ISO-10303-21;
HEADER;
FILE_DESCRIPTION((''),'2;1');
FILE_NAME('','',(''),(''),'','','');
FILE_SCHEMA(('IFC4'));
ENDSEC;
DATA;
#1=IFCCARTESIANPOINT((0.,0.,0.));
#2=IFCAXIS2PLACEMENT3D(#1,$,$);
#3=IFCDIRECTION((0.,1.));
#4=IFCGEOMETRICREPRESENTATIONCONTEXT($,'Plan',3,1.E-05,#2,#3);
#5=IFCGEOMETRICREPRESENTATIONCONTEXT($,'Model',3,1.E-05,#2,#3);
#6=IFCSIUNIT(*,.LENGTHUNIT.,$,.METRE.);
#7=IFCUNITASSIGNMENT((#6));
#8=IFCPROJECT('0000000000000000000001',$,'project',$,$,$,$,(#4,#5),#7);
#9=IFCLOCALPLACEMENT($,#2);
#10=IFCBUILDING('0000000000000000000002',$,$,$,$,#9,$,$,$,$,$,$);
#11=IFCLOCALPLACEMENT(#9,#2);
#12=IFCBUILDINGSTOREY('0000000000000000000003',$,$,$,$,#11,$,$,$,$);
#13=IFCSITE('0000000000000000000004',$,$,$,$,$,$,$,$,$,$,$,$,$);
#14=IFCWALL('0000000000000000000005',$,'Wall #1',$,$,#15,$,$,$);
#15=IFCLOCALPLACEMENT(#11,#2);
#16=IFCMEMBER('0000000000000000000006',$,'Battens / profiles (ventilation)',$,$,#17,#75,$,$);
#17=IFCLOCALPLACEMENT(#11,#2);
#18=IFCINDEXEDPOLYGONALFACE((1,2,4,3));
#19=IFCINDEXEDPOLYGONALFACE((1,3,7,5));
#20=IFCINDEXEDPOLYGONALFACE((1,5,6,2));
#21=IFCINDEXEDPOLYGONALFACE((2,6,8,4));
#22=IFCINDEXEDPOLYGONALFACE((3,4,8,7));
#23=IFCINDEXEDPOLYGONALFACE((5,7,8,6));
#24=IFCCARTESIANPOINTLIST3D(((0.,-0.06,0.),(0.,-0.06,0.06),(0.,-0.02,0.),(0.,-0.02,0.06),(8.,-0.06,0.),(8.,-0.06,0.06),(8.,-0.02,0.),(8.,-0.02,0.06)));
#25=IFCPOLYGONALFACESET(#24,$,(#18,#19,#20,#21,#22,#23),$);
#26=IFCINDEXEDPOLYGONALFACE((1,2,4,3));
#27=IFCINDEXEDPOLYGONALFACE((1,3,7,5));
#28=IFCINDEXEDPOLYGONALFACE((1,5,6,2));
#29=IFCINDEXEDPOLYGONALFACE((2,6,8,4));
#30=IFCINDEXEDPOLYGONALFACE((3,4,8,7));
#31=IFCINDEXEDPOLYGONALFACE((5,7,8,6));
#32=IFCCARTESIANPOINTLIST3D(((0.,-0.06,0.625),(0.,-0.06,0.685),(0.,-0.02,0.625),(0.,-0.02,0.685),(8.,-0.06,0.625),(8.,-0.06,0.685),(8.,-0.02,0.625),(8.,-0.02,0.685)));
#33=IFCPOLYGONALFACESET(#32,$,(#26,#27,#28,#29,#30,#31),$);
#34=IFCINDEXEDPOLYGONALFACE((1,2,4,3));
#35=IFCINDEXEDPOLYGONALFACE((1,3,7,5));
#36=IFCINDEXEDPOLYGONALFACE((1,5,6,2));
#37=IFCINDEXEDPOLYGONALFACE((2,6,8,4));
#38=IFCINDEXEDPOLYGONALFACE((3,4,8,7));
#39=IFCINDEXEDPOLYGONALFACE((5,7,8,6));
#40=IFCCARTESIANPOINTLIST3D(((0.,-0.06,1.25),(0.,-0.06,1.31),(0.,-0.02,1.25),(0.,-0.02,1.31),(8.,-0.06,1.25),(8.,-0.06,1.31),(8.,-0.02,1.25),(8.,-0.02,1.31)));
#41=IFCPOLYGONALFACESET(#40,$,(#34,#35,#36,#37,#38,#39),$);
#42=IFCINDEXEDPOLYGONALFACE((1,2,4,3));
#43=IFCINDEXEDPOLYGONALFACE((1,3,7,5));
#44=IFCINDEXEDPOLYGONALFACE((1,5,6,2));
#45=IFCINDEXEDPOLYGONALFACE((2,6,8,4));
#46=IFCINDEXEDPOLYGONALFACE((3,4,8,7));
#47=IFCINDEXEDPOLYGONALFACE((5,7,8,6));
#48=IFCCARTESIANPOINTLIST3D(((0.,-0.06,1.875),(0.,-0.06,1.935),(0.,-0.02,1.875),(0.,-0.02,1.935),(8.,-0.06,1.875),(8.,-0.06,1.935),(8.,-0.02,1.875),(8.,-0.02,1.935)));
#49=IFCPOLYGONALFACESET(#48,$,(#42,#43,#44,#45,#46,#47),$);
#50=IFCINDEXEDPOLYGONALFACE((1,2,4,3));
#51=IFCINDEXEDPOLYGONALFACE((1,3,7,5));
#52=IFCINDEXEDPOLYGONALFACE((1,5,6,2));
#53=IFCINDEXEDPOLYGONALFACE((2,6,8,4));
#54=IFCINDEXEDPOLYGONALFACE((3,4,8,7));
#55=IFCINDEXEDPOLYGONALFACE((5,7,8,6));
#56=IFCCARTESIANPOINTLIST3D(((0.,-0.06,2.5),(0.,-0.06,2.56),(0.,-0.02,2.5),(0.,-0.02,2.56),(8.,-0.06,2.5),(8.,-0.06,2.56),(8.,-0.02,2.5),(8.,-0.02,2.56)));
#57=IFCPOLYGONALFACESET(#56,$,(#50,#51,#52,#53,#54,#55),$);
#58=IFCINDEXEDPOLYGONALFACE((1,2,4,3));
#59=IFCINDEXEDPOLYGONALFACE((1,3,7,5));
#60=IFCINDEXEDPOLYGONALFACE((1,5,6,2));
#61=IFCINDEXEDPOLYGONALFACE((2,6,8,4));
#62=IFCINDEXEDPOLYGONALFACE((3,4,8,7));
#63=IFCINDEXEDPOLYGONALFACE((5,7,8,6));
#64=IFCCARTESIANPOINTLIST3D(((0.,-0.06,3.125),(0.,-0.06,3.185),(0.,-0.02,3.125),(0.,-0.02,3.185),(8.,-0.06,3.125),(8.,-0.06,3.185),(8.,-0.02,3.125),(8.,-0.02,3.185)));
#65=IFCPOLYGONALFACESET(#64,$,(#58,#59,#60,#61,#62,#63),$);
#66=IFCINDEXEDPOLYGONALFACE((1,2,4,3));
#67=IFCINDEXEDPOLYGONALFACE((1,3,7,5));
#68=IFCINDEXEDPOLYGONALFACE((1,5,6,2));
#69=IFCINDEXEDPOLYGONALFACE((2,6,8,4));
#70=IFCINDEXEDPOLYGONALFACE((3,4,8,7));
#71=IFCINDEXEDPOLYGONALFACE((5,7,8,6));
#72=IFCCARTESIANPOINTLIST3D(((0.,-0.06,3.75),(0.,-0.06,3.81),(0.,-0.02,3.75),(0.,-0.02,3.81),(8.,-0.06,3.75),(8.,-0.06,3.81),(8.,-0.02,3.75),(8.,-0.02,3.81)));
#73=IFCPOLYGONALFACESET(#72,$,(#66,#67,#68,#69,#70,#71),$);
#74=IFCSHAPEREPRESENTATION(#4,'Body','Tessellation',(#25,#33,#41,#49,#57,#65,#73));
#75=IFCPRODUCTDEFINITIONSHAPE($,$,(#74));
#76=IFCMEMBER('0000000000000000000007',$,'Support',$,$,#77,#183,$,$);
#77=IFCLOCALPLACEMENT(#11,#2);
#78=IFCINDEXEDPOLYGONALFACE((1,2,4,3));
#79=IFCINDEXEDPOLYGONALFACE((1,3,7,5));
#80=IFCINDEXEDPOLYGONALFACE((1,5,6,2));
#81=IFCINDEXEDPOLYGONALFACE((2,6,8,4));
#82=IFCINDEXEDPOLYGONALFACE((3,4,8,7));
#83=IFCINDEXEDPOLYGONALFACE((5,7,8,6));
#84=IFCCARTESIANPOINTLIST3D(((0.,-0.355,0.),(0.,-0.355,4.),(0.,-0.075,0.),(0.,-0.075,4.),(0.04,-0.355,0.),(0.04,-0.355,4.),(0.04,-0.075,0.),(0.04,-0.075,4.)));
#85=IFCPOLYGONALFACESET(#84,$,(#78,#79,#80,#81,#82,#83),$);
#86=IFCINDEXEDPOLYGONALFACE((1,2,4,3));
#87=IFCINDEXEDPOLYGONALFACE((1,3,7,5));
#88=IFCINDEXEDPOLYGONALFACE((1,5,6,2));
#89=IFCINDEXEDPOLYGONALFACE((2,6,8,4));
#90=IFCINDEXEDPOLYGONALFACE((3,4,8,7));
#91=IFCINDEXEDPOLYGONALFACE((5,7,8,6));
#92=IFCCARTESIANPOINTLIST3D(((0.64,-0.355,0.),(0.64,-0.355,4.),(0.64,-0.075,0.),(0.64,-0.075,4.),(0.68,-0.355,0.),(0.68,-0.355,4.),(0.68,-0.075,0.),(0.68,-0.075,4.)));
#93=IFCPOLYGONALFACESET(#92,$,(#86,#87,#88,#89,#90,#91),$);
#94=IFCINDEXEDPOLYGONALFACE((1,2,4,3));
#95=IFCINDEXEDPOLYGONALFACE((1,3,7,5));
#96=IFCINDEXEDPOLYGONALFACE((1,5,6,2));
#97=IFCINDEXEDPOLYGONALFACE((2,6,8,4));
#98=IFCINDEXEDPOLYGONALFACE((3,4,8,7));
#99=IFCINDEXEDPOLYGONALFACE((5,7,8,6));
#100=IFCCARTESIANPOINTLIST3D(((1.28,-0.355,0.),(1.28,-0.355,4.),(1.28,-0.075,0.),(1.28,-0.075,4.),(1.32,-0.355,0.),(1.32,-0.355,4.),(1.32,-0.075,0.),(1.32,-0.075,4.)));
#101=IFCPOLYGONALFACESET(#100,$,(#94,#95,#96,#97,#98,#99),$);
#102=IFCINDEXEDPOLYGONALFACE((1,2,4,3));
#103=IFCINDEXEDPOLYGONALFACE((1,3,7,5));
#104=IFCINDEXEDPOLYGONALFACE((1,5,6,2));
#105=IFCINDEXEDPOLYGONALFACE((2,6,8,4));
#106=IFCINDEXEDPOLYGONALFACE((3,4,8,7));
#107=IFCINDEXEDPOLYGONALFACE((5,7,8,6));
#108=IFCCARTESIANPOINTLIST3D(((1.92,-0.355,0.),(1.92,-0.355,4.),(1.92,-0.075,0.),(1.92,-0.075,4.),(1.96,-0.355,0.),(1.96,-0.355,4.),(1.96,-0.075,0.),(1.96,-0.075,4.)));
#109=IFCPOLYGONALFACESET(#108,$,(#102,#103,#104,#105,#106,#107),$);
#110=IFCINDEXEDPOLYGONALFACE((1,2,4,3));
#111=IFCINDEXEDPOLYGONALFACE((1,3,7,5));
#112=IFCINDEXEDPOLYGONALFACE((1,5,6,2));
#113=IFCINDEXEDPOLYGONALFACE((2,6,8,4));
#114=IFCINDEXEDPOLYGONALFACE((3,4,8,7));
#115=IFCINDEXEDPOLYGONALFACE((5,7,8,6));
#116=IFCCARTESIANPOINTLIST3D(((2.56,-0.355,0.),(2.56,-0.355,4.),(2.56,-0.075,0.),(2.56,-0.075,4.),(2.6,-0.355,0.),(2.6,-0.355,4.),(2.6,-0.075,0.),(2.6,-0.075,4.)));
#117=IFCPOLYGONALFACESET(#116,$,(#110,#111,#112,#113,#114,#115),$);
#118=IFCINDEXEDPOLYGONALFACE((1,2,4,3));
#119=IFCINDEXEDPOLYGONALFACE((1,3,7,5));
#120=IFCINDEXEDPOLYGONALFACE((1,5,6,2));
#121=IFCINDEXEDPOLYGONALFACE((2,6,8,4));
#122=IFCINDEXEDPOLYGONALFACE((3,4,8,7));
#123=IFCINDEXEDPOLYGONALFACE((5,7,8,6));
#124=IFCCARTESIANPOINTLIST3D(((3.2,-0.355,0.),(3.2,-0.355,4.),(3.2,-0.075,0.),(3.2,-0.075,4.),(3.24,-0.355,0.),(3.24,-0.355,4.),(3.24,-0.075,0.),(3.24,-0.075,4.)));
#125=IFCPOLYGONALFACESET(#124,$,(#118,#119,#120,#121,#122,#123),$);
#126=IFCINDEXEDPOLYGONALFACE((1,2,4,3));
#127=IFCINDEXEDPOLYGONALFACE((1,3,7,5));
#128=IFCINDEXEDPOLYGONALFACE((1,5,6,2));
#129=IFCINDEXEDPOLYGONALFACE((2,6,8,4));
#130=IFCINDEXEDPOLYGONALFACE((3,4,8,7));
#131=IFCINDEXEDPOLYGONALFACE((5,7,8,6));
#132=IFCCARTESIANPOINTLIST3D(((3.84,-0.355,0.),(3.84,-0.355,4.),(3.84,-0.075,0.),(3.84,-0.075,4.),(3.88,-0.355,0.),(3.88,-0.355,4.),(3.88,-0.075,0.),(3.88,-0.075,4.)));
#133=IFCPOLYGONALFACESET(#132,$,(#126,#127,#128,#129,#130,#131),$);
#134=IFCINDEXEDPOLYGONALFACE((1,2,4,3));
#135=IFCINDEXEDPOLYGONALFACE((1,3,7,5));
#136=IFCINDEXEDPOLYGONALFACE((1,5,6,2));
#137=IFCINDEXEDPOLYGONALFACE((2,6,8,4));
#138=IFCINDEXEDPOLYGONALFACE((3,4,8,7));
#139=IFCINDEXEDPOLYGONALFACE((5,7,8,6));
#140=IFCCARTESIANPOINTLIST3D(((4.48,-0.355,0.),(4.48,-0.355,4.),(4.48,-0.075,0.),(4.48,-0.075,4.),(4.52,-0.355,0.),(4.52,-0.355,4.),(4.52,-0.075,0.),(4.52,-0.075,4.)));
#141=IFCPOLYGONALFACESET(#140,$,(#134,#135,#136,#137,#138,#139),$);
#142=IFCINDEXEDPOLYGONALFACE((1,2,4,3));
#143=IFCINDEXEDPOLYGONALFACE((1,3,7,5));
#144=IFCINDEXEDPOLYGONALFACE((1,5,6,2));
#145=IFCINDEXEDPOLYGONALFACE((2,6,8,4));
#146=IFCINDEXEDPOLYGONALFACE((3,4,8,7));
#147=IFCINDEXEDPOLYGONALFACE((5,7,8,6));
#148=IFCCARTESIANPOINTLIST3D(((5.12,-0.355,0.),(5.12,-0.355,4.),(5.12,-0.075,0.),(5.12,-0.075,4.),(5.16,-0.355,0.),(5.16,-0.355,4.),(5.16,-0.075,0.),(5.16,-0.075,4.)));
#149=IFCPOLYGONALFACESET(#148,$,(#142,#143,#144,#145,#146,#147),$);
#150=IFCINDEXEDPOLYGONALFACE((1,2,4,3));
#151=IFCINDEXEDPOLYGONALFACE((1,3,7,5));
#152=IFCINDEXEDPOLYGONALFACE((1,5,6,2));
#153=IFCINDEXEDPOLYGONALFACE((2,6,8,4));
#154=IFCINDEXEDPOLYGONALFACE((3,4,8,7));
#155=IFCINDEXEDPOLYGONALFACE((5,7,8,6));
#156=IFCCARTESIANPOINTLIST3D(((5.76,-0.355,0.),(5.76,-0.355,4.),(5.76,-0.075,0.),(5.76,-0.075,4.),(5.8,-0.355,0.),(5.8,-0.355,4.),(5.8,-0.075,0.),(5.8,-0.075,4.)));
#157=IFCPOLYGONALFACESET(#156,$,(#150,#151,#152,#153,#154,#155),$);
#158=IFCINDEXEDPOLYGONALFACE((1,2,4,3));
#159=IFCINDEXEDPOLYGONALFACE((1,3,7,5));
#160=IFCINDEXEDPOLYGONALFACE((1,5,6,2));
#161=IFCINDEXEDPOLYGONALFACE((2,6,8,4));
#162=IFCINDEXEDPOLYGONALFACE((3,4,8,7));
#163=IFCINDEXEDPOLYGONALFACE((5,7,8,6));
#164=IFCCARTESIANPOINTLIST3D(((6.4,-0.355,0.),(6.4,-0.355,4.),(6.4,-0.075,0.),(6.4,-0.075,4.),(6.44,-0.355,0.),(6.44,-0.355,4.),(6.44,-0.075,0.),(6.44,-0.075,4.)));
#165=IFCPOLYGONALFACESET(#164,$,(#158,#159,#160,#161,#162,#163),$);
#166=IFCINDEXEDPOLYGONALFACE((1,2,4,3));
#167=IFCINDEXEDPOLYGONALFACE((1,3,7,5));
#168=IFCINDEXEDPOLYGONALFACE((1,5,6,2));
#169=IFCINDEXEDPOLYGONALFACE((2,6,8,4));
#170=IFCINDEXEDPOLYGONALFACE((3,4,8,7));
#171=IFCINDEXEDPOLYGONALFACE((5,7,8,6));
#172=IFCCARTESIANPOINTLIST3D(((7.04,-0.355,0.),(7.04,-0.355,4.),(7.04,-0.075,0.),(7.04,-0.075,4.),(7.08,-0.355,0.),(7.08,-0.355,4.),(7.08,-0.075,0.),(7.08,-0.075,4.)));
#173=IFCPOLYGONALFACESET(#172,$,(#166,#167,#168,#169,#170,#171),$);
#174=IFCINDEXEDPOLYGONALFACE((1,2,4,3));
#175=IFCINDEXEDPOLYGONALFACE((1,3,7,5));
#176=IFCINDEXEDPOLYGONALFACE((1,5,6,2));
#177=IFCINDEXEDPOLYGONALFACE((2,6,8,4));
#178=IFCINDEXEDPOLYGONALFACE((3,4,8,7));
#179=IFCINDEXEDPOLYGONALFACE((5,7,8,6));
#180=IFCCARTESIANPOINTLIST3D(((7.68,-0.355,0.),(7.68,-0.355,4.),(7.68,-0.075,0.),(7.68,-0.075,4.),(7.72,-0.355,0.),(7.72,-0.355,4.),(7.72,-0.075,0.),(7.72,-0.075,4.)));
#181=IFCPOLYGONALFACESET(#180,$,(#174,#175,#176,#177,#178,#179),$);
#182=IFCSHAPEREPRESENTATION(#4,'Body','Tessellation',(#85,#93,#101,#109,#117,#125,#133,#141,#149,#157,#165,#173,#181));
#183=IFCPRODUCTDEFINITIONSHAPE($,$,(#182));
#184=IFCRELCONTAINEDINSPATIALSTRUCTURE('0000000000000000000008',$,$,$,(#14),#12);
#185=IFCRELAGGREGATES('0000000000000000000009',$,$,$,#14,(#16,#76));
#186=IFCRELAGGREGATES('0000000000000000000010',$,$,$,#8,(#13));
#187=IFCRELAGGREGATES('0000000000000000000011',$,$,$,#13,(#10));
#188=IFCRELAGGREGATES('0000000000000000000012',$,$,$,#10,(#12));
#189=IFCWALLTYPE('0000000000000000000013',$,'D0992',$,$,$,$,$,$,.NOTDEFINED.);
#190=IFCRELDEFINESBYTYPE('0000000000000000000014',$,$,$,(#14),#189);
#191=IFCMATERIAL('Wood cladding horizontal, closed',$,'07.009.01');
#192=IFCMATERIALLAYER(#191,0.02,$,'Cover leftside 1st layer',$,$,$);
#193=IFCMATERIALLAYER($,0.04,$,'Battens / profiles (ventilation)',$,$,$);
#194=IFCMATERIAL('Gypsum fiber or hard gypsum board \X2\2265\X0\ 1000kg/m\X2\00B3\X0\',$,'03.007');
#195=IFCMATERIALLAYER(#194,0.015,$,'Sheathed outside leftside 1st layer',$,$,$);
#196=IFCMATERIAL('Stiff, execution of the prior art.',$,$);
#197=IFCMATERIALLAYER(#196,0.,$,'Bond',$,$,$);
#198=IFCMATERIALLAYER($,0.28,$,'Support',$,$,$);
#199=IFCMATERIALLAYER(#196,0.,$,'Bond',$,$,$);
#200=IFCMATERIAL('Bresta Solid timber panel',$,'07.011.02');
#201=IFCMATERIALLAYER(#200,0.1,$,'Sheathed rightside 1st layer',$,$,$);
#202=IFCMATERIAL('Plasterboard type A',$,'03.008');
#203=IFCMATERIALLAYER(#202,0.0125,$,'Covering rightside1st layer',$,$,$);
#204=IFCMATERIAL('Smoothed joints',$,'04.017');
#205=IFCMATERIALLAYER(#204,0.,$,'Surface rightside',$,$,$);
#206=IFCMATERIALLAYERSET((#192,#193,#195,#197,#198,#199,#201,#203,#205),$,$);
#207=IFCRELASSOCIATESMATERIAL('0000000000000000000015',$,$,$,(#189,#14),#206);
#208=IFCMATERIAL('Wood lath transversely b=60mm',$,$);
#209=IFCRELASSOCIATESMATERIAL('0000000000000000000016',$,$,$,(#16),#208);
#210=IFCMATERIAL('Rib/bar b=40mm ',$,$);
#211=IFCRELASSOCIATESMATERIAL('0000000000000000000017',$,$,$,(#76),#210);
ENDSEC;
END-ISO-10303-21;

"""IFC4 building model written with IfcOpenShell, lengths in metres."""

from ifc_helpers import new_model, si_unit, direction, frame, frame_2d, origin, place, context, project, spatial, rectangle, extrude, material, layer, layer_set, type_object, element, aggregate, save


model = new_model("IFC4")

# Units and contexts
plan_context = context("Plan", 3, precision=1e-05, world=origin(), true_north=direction((0.0, 1.0)))
model_context = context("Model", 3, precision=1e-05, world=origin(), true_north=direction((0.0, 1.0)))
ifc_project = project(units=[si_unit("LENGTHUNIT", "METRE")], contexts=[plan_context, model_context])

# Site, building, storey
site = spatial("IfcSite", under=ifc_project)
building_placement = place(None, origin())
building = spatial("IfcBuilding", under=site, at=building_placement)
storey_placement = place(building_placement, origin())
storey = spatial("IfcBuildingStorey", under=building, at=storey_placement)

# Wall, members
ifc_material_1 = material(Name="Wood cladding horizontal, closed", Category="07.009.01")
ifc_layer_1 = layer(ifc_material_1, 0.02, Name="Cover leftside 1st layer")
ifc_layer_2 = layer(None, 0.04, Name="Battens / profiles (ventilation)")
ifc_material_2 = material(Name="Gypsum fiber or hard gypsum board ≥ 1000kg/m³", Category="03.007")
ifc_layer_3 = layer(ifc_material_2, 0.015, Name="Sheathed outside leftside 1st layer")
ifc_material_3 = material(Name="Stiff, execution of the prior art.")
ifc_layer_4 = layer(ifc_material_3, 0.0, Name="Bond")
ifc_layer_5 = layer(None, 0.28, Name="Support")
ifc_layer_6 = layer(ifc_material_3, 0.0, Name="Bond")
ifc_material_4 = material(Name="Bresta Solid timber panel", Category="07.011.02")
ifc_layer_7 = layer(ifc_material_4, 0.1, Name="Sheathed rightside 1st layer")
ifc_material_5 = material(Name="Plasterboard type A", Category="03.008")
ifc_layer_8 = layer(ifc_material_5, 0.0125, Name="Covering rightside1st layer")
ifc_material_6 = material(Name="Smoothed joints", Category="04.017")
ifc_layer_9 = layer(ifc_material_6, 0.0, Name="Surface rightside")
ifc_layer_set = layer_set([ifc_layer_1, ifc_layer_2, ifc_layer_3, ifc_layer_4, ifc_layer_5, ifc_layer_6, ifc_layer_7, ifc_layer_8, ifc_layer_9])
wall_type = type_object("IfcWallType", Name="D0992", PredefinedType="NOTDEFINED", material=ifc_layer_set)
wall_placement = place(None, frame((0.0, 0.0, 0.0), z_axis=(0.0, -1.0, 0.0), x_axis=(1.0, 0.0, 0.0)))
wall = element("IfcWall", 1, at=wall_placement, inside=storey, type_object=wall_type, material=ifc_layer_set, Name="Wall #1")
ifc_material_7 = material(Name="Wood lath transversely b=60mm")
member_1_placement = place(wall_placement, origin())
member_1 = element("IfcMember", 2, at=member_1_placement, material=ifc_material_7, Name="Battens / profiles (ventilation)", context=plan_context, shape_type="SweptSolid", body=[
    extrude(rectangle(XDim=0.06, YDim=0.04, at=frame_2d((0.03, 0.02), x_axis=(1.0, 0.0))), frame((0.0, 0.0, 0.02), z_axis=(1.0, 0.0, 0.0), x_axis=(0.0, 1.0, 0.0)), (0.0, 0.0, 1.0), 8.0),
    extrude(rectangle(XDim=0.06, YDim=0.04, at=frame_2d((0.03, 0.02), x_axis=(1.0, 0.0))), frame((0.0, 0.625, 0.02), z_axis=(1.0, 0.0, 0.0), x_axis=(0.0, 1.0, 0.0)), (0.0, 0.0, 1.0), 8.0),
    extrude(rectangle(XDim=0.06, YDim=0.04, at=frame_2d((0.03, 0.02), x_axis=(1.0, 0.0))), frame((0.0, 1.25, 0.02), z_axis=(1.0, 0.0, 0.0), x_axis=(0.0, 1.0, 0.0)), (0.0, 0.0, 1.0), 8.0),
    extrude(rectangle(XDim=0.06, YDim=0.04, at=frame_2d((0.03, 0.02), x_axis=(1.0, 0.0))), frame((0.0, 1.875, 0.02), z_axis=(1.0, 0.0, 0.0), x_axis=(0.0, 1.0, 0.0)), (0.0, 0.0, 1.0), 8.0),
    extrude(rectangle(XDim=0.06, YDim=0.04, at=frame_2d((0.03, 0.02), x_axis=(1.0, 0.0))), frame((0.0, 2.5, 0.02), z_axis=(1.0, 0.0, 0.0), x_axis=(0.0, 1.0, 0.0)), (0.0, 0.0, 1.0), 8.0),
    extrude(rectangle(XDim=0.06, YDim=0.04, at=frame_2d((0.03, 0.02), x_axis=(1.0, 0.0))), frame((0.0, 3.125, 0.02), z_axis=(1.0, 0.0, 0.0), x_axis=(0.0, 1.0, 0.0)), (0.0, 0.0, 1.0), 8.0),
    extrude(rectangle(XDim=0.06, YDim=0.04, at=frame_2d((0.03, 0.02), x_axis=(1.0, 0.0))), frame((0.0, 3.75, 0.02), z_axis=(1.0, 0.0, 0.0), x_axis=(0.0, 1.0, 0.0)), (0.0, 0.0, 1.0), 8.0),
])
ifc_material_8 = material(Name="Rib/bar b=40mm ")
member_2_placement = place(wall_placement, origin())
member_2 = element("IfcMember", 3, at=member_2_placement, material=ifc_material_8, Name="Support", context=plan_context, shape_type="SweptSolid", body=[
    extrude(rectangle(XDim=0.04, YDim=0.28, at=frame_2d((0.02, 0.14), x_axis=(1.0, 0.0))), frame((0.0, 4.0, 0.075), z_axis=(0.0, -1.0, 0.0), x_axis=(1.0, 0.0, 0.0)), (0.0, 0.0, 1.0), 4.0),
    extrude(rectangle(XDim=0.04, YDim=0.28, at=frame_2d((0.02, 0.14), x_axis=(1.0, 0.0))), frame((0.64, 4.0, 0.075), z_axis=(0.0, -1.0, 0.0), x_axis=(1.0, 0.0, 0.0)), (0.0, 0.0, 1.0), 4.0),
    extrude(rectangle(XDim=0.04, YDim=0.28, at=frame_2d((0.02, 0.14), x_axis=(1.0, 0.0))), frame((1.28, 4.0, 0.075), z_axis=(0.0, -1.0, 0.0), x_axis=(1.0, 0.0, 0.0)), (0.0, 0.0, 1.0), 4.0),
    extrude(rectangle(XDim=0.04, YDim=0.28, at=frame_2d((0.02, 0.14), x_axis=(1.0, 0.0))), frame((1.92, 4.0, 0.075), z_axis=(0.0, -1.0, 0.0), x_axis=(1.0, 0.0, 0.0)), (0.0, 0.0, 1.0), 4.0),
    extrude(rectangle(XDim=0.04, YDim=0.28, at=frame_2d((0.02, 0.14), x_axis=(1.0, 0.0))), frame((2.56, 4.0, 0.075), z_axis=(0.0, -1.0, 0.0), x_axis=(1.0, 0.0, 0.0)), (0.0, 0.0, 1.0), 4.0),
    extrude(rectangle(XDim=0.04, YDim=0.28, at=frame_2d((0.02, 0.14), x_axis=(1.0, 0.0))), frame((3.2, 4.0, 0.075), z_axis=(0.0, -1.0, 0.0), x_axis=(1.0, 0.0, 0.0)), (0.0, 0.0, 1.0), 4.0),
    extrude(rectangle(XDim=0.04, YDim=0.28, at=frame_2d((0.02, 0.14), x_axis=(1.0, 0.0))), frame((3.84, 4.0, 0.075), z_axis=(0.0, -1.0, 0.0), x_axis=(1.0, 0.0, 0.0)), (0.0, 0.0, 1.0), 4.0),
    extrude(rectangle(XDim=0.04, YDim=0.28, at=frame_2d((0.02, 0.14), x_axis=(1.0, 0.0))), frame((4.48, 4.0, 0.075), z_axis=(0.0, -1.0, 0.0), x_axis=(1.0, 0.0, 0.0)), (0.0, 0.0, 1.0), 4.0),
    extrude(rectangle(XDim=0.04, YDim=0.28, at=frame_2d((0.02, 0.14), x_axis=(1.0, 0.0))), frame((5.12, 4.0, 0.075), z_axis=(0.0, -1.0, 0.0), x_axis=(1.0, 0.0, 0.0)), (0.0, 0.0, 1.0), 4.0),
    extrude(rectangle(XDim=0.04, YDim=0.28, at=frame_2d((0.02, 0.14), x_axis=(1.0, 0.0))), frame((5.76, 4.0, 0.075), z_axis=(0.0, -1.0, 0.0), x_axis=(1.0, 0.0, 0.0)), (0.0, 0.0, 1.0), 4.0),
    extrude(rectangle(XDim=0.04, YDim=0.28, at=frame_2d((0.02, 0.14), x_axis=(1.0, 0.0))), frame((6.4, 4.0, 0.075), z_axis=(0.0, -1.0, 0.0), x_axis=(1.0, 0.0, 0.0)), (0.0, 0.0, 1.0), 4.0),
    extrude(rectangle(XDim=0.04, YDim=0.28, at=frame_2d((0.02, 0.14), x_axis=(1.0, 0.0))), frame((7.04, 4.0, 0.075), z_axis=(0.0, -1.0, 0.0), x_axis=(1.0, 0.0, 0.0)), (0.0, 0.0, 1.0), 4.0),
    extrude(rectangle(XDim=0.04, YDim=0.28, at=frame_2d((0.02, 0.14), x_axis=(1.0, 0.0))), frame((7.68, 4.0, 0.075), z_axis=(0.0, -1.0, 0.0), x_axis=(1.0, 0.0, 0.0)), (0.0, 0.0, 1.0), 4.0),
])
aggregate(wall, [member_1, member_2])

save(model, "model.ifc")
